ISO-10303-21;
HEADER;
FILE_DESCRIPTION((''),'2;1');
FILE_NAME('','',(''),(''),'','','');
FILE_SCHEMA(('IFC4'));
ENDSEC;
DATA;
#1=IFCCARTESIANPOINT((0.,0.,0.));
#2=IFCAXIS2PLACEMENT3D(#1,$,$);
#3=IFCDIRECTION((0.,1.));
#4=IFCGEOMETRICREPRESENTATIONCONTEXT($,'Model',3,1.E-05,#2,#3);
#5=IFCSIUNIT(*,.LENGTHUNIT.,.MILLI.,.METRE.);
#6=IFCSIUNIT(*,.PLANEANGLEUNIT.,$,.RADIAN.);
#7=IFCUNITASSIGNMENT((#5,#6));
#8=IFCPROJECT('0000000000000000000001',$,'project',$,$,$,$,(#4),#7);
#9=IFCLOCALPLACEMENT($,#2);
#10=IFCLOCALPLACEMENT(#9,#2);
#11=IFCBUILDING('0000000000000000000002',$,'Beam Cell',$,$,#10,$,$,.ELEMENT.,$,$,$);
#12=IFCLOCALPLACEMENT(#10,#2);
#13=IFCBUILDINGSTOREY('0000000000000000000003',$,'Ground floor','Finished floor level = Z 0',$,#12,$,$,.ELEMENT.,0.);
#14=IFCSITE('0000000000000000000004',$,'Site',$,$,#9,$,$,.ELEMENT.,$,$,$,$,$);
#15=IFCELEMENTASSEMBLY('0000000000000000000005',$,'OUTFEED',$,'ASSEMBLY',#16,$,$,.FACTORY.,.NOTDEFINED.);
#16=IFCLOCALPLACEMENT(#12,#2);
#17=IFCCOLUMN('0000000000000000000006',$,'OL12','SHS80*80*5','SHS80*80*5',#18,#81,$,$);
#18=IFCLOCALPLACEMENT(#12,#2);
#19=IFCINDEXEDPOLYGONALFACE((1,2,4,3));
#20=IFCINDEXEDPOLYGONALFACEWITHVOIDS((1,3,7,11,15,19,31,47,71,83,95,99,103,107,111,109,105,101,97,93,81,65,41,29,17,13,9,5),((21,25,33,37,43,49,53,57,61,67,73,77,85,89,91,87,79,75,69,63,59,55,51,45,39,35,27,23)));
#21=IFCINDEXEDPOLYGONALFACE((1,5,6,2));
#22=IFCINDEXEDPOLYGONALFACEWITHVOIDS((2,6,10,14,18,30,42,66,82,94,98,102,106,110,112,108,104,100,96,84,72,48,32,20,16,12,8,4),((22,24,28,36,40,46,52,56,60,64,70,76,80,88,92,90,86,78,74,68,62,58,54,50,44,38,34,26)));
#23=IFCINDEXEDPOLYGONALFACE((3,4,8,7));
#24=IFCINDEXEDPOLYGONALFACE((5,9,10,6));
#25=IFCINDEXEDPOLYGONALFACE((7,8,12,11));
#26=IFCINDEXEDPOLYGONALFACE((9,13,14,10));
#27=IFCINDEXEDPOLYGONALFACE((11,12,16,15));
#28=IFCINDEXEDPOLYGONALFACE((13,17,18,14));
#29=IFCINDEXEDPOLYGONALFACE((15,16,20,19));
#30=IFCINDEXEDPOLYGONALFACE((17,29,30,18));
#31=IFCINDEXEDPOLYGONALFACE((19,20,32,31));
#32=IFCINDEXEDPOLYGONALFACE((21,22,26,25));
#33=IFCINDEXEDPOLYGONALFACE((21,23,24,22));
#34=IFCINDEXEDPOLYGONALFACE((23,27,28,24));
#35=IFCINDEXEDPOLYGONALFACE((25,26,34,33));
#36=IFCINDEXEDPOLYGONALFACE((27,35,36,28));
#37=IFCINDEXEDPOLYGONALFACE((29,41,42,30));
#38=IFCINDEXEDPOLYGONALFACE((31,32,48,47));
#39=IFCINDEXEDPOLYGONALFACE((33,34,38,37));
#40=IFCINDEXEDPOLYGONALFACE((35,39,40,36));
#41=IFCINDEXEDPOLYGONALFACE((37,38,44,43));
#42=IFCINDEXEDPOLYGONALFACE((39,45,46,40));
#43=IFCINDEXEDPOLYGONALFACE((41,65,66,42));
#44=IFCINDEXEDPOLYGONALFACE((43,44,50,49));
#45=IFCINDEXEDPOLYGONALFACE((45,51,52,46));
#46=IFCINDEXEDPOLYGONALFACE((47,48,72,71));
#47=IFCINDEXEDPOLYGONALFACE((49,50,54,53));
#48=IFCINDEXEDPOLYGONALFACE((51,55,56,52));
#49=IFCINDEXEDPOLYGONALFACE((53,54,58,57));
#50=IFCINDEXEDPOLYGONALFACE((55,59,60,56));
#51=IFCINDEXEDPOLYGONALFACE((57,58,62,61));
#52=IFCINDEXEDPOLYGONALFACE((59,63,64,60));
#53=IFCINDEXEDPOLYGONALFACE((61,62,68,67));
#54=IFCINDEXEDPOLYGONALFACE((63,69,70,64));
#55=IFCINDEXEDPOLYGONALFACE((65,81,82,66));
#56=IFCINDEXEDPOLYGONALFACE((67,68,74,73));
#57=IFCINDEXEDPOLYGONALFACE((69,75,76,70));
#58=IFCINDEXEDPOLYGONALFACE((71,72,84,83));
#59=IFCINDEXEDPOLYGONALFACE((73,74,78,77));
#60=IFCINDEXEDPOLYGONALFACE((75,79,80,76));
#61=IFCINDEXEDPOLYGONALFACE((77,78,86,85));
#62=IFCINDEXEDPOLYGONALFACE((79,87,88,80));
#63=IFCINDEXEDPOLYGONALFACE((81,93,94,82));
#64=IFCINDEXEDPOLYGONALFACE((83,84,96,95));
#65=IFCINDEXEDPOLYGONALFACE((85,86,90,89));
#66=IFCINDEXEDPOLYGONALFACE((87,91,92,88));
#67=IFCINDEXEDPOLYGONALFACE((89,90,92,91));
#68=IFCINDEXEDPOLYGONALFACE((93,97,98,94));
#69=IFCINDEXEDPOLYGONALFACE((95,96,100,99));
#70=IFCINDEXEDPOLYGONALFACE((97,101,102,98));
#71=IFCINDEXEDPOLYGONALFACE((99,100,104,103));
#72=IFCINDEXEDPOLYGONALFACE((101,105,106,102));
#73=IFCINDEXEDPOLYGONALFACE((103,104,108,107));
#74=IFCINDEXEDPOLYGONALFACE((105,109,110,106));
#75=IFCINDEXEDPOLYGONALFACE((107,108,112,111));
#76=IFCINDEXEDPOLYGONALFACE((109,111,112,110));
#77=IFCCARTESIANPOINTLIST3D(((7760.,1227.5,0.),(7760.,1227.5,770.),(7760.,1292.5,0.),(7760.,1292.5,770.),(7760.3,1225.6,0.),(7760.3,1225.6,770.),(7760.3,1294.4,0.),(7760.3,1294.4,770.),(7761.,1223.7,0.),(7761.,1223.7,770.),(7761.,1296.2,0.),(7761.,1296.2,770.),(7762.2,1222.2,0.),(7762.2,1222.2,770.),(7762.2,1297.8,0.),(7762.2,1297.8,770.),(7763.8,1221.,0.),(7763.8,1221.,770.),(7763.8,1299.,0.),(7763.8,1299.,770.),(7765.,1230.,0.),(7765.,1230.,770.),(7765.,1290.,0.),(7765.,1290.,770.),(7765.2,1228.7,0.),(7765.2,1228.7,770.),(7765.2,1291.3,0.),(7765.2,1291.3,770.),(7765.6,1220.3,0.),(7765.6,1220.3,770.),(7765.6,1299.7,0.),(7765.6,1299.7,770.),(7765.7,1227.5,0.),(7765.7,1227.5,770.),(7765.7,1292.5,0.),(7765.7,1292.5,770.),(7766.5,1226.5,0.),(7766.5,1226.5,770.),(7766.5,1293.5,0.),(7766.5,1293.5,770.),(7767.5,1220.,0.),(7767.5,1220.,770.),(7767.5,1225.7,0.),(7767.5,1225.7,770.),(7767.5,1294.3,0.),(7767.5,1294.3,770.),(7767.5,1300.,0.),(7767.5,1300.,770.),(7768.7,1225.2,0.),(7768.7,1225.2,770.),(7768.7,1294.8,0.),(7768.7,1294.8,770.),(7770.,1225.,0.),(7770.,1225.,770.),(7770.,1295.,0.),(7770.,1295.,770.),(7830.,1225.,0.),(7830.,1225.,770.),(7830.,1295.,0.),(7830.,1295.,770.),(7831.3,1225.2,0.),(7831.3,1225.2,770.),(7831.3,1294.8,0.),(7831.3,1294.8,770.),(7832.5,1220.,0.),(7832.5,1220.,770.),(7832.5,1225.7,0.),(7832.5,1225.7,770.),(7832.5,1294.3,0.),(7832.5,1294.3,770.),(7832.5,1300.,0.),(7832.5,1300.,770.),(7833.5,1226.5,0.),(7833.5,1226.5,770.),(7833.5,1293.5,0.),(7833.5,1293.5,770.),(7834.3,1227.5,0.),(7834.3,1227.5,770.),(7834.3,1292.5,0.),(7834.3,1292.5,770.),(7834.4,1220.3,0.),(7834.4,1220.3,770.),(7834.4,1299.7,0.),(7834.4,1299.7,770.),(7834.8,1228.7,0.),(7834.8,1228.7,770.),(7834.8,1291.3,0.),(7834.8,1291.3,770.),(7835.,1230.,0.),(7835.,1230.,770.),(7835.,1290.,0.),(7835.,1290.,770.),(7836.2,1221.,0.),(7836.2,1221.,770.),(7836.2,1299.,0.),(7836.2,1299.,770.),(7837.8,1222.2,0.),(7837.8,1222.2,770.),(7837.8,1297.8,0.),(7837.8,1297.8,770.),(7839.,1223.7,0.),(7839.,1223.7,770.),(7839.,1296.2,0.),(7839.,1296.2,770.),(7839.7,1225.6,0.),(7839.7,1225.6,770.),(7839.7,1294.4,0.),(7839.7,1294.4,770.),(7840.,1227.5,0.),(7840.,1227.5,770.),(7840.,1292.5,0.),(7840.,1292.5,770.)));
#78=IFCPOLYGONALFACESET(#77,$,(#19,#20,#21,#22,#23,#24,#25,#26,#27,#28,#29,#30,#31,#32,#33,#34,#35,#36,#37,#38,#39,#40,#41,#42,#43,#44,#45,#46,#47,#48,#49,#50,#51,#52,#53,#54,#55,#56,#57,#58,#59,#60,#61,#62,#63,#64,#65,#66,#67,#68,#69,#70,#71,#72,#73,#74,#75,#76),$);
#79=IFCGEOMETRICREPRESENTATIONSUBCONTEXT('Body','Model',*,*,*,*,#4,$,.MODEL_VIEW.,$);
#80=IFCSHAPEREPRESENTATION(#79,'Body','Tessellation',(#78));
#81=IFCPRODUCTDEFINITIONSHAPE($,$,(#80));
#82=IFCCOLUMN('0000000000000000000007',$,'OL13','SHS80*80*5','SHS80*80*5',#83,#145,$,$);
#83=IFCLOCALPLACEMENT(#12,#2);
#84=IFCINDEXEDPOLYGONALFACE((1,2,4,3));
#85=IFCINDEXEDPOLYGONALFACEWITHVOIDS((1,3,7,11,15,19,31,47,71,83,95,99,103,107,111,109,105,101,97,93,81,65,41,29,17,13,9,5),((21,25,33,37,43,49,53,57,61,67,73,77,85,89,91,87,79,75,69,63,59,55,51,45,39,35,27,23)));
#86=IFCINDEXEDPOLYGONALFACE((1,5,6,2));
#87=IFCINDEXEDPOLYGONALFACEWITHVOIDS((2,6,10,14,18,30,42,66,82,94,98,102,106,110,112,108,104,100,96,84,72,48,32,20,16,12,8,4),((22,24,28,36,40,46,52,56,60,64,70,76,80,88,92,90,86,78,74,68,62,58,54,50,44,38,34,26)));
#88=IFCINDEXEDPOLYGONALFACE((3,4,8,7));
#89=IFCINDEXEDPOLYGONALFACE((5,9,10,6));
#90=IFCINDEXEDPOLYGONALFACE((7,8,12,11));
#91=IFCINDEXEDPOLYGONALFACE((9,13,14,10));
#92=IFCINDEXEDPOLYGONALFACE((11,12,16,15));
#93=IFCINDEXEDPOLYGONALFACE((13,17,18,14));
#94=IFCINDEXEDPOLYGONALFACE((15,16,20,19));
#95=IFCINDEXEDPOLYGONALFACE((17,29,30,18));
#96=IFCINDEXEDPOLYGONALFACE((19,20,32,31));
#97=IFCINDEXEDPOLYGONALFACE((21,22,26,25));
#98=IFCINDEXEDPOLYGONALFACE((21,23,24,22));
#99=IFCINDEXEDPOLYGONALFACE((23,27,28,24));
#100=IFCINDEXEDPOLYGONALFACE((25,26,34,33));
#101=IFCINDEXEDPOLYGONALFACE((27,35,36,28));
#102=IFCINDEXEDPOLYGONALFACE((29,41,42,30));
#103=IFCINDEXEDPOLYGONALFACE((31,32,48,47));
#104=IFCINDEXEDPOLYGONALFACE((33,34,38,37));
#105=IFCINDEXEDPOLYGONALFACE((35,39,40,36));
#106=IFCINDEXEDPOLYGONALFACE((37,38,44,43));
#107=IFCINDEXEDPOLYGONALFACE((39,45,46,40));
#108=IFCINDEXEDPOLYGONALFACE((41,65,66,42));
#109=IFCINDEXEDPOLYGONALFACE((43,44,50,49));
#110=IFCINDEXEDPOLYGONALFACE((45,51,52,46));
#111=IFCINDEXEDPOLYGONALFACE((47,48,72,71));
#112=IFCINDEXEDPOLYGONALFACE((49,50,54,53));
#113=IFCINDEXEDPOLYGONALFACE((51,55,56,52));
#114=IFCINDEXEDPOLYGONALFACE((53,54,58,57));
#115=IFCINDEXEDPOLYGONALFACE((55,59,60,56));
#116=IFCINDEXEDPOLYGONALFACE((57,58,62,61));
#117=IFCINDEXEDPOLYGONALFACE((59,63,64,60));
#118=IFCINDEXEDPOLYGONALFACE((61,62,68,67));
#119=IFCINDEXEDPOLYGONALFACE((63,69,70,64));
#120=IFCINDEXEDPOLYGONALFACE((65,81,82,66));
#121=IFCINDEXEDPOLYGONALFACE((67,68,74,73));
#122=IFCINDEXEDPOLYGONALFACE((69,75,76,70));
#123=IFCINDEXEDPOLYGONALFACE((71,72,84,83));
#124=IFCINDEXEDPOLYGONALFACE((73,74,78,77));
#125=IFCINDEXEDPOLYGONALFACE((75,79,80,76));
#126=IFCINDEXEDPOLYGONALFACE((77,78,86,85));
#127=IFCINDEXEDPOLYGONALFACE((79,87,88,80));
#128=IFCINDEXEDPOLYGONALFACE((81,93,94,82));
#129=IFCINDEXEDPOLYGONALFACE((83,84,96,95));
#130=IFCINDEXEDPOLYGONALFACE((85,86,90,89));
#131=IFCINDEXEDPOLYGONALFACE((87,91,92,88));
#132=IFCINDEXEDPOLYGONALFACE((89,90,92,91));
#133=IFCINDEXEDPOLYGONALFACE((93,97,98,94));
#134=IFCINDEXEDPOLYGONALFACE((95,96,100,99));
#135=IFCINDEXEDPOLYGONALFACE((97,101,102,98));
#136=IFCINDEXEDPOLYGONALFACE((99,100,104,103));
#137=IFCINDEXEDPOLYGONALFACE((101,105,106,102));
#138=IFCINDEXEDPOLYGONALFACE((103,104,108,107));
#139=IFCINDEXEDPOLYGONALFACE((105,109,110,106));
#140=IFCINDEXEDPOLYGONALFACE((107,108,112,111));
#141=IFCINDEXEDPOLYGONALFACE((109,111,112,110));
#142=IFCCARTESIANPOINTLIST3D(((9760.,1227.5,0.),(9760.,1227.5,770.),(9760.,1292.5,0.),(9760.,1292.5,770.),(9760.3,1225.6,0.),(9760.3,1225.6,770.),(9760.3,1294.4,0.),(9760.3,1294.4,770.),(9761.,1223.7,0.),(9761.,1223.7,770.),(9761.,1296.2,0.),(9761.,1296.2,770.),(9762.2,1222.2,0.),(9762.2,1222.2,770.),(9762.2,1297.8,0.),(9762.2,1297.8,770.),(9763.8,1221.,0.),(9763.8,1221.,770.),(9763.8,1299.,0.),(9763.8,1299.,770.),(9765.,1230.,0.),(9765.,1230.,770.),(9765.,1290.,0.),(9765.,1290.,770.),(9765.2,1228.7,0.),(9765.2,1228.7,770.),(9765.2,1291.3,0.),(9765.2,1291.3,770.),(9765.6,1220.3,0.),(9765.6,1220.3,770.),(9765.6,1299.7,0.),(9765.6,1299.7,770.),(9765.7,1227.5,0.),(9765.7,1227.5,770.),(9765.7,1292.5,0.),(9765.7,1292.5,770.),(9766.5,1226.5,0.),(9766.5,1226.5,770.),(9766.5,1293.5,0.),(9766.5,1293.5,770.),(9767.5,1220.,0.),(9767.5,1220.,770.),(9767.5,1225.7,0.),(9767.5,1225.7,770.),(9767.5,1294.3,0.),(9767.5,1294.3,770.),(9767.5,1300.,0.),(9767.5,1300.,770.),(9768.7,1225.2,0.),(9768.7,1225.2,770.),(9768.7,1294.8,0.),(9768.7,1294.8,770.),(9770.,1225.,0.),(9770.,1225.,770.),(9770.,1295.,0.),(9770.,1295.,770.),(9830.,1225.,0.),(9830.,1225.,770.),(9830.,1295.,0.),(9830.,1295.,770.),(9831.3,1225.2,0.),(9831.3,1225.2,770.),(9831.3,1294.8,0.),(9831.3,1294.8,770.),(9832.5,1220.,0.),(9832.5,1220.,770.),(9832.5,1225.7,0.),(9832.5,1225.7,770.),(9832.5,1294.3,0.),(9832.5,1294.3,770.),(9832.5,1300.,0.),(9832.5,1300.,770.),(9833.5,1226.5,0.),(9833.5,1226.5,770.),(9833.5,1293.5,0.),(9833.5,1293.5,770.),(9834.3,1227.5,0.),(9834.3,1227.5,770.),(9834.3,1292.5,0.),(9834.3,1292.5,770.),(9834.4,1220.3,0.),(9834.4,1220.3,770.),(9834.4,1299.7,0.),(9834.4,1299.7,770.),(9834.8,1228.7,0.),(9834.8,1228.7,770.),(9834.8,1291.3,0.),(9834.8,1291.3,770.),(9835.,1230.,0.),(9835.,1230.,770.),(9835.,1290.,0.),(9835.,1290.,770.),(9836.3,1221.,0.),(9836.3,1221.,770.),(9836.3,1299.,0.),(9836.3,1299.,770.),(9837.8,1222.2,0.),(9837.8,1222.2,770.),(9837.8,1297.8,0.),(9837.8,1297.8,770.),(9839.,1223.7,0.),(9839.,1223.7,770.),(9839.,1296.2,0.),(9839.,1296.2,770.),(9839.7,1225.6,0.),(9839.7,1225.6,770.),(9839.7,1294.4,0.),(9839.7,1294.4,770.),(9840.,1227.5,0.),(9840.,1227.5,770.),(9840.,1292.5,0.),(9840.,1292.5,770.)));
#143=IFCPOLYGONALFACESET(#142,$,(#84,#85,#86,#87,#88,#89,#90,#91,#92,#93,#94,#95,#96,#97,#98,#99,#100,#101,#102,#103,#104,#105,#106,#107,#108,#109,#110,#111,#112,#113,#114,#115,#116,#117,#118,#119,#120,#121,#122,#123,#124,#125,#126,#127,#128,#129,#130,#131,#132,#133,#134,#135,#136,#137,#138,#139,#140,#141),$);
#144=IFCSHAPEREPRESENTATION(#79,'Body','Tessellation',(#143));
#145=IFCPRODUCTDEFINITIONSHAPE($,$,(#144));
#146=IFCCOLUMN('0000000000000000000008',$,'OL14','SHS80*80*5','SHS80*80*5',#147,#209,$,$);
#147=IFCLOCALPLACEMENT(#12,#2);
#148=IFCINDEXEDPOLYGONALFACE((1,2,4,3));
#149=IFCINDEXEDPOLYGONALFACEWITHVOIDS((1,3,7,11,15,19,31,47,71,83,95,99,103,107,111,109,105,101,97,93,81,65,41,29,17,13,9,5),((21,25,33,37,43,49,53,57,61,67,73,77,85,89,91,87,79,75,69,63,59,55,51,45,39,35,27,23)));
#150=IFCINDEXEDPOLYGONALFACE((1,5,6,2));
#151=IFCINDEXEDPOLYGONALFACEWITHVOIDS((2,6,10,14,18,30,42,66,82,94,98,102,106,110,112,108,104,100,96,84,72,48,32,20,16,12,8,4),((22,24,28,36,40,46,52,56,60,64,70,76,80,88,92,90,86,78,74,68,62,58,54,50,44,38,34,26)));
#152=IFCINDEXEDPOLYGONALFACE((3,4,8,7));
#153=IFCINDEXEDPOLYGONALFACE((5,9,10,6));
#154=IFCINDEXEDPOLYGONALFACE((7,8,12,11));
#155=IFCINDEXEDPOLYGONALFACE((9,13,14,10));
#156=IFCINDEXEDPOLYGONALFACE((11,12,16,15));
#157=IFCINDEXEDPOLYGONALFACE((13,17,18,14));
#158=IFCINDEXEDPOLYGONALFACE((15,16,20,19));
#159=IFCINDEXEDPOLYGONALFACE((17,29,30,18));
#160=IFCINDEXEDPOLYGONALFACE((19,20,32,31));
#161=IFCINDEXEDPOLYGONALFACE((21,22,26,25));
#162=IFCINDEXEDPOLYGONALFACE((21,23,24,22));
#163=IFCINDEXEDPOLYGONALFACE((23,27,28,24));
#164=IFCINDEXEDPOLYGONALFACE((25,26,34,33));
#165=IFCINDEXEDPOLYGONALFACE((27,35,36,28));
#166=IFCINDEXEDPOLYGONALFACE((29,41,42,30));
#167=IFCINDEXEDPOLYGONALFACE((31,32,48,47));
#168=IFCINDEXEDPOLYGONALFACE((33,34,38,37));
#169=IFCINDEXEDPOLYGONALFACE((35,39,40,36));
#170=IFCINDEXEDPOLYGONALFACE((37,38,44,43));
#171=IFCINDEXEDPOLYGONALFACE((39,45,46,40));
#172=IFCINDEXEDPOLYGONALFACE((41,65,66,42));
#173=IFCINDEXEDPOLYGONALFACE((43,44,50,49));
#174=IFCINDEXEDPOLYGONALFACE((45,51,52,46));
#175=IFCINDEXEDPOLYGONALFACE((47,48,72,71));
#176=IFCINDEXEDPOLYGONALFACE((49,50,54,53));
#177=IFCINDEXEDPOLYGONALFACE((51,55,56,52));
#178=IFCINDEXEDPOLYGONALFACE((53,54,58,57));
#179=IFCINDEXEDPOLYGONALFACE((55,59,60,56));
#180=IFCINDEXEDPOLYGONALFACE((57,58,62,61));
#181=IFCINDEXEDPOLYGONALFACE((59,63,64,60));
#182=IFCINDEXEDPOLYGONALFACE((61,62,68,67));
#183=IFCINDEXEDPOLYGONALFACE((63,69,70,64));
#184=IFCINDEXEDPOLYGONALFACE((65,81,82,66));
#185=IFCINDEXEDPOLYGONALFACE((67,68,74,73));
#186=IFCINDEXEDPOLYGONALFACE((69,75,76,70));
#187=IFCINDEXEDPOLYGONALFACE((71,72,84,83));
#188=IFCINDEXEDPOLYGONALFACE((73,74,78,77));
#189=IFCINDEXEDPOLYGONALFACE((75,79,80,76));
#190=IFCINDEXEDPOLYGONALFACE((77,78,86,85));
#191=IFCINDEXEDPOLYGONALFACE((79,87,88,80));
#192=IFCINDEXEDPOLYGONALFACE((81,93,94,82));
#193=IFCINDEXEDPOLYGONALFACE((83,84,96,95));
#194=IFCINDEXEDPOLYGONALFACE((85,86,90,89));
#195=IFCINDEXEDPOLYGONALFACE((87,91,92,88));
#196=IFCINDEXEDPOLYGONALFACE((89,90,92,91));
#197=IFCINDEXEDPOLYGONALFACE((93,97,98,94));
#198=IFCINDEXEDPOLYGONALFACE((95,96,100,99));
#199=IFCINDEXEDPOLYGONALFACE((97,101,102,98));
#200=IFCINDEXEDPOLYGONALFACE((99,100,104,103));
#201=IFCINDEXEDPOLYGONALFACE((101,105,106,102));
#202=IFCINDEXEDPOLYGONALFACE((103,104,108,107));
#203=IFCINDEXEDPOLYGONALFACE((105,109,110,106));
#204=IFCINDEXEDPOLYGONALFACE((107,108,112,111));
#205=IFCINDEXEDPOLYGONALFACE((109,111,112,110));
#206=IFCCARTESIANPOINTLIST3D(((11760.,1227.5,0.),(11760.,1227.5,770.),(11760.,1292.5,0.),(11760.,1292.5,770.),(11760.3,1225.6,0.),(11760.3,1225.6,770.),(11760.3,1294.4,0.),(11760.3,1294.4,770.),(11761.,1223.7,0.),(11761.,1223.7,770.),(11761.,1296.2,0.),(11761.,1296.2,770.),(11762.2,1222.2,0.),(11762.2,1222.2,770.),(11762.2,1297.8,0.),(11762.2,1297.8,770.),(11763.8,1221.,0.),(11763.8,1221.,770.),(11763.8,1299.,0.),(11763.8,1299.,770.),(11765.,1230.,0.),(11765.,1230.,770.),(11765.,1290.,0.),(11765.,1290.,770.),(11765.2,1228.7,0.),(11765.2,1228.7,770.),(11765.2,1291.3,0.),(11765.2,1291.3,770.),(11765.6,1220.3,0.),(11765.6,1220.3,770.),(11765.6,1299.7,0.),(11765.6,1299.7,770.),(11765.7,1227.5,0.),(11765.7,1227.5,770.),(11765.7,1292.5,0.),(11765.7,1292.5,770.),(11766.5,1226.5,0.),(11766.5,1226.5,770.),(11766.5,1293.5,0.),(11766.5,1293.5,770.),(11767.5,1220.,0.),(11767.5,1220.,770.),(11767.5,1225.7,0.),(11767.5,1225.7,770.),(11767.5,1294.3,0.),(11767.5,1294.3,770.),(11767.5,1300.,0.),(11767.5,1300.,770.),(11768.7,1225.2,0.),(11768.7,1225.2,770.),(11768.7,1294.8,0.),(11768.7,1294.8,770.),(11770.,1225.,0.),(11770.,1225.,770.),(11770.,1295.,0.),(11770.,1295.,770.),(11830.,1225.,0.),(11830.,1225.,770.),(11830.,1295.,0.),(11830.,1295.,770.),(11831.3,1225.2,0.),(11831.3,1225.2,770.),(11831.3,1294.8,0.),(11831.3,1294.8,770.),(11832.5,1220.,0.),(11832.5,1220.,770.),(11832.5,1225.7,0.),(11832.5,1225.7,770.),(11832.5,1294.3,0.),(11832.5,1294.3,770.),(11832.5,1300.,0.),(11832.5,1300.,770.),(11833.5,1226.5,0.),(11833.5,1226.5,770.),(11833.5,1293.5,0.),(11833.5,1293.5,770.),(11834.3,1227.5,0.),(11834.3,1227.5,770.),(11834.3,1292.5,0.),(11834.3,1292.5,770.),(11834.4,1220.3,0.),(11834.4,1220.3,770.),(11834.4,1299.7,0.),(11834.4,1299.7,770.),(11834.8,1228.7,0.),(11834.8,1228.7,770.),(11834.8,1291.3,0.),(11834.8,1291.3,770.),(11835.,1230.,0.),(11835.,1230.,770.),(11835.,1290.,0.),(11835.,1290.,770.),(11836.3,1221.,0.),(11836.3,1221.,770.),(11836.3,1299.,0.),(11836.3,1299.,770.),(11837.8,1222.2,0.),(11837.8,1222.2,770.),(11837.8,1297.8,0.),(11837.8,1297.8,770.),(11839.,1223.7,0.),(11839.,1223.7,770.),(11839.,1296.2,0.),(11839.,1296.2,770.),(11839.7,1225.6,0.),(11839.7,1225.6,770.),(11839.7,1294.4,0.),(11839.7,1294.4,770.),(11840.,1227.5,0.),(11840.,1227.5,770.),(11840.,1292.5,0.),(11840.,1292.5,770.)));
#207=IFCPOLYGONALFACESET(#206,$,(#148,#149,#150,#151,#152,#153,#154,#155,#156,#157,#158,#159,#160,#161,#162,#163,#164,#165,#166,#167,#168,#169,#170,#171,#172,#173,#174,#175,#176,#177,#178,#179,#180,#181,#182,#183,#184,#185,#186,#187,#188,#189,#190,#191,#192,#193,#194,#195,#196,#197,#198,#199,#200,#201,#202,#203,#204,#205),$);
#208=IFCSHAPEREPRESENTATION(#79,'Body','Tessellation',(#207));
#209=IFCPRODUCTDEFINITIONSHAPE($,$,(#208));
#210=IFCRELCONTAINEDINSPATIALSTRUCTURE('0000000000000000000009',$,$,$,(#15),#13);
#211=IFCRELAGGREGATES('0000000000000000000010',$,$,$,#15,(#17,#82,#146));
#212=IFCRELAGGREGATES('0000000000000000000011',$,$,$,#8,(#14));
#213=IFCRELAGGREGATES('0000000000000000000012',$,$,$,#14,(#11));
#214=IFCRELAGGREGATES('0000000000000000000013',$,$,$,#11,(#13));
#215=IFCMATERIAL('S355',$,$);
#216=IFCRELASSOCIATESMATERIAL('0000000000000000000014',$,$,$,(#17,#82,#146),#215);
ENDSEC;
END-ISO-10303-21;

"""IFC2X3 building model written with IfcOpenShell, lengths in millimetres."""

from ifc_helpers import new_model, si_unit, direction, frame, origin, origin_2d, place, context, subcontext, project, spatial, hollow_rectangle, extrude, material, element, aggregate, save


model = new_model("IFC2X3")

# Units and contexts
model_context = context("Model", 3, precision=1e-05, world=origin(), true_north=direction((0.0, 1.0)))
body_context = subcontext(model_context, "Body", "Model", "MODEL_VIEW")
ifc_project = project(units=[si_unit("LENGTHUNIT", "METRE", prefix="MILLI"), si_unit("PLANEANGLEUNIT", "RADIAN")], contexts=[model_context])

# Site, building, storey
site_placement = place(None, origin())
site = spatial("IfcSite", under=ifc_project, at=site_placement, Name="Site", CompositionType="ELEMENT")
building_placement = place(site_placement, origin())
building = spatial("IfcBuilding", under=site, at=building_placement, Name="Beam Cell", CompositionType="ELEMENT")
storey_placement = place(building_placement, origin())
storey = spatial("IfcBuildingStorey", under=building, at=storey_placement, Name="Ground floor", Description="Finished floor level = Z 0", CompositionType="ELEMENT", Elevation=0.0)

# Element assembly, columns
ifc_material = material(Name="S355")
assembly_1_placement = place(storey_placement, origin())
assembly_1 = element("IfcElementAssembly", 1, at=assembly_1_placement, inside=storey, Name="OUTFEED", ObjectType="ASSEMBLY", AssemblyPlace="FACTORY", PredefinedType="NOTDEFINED")
column_1_placement = place(storey_placement, frame((7800.0, 1260.0, 0.0), z_axis=(0.0, 0.0, 1.0), x_axis=(1.0, 0.0, 0.0)))
column_1 = element("IfcColumn", 2, at=column_1_placement, material=ifc_material, Name="OL12", Description="SHS80*80*5", ObjectType="SHS80*80*5", context=body_context, shape_type="SweptSolid", body=[
    extrude(hollow_rectangle(XDim=80.0, YDim=80.0, WallThickness=5.0, InnerFilletRadius=5.0, OuterFilletRadius=7.5, at=origin_2d()), origin(), (0.0, 0.0, 1.0), 770.0),
])
column_2_placement = place(storey_placement, frame((9800.0, 1260.0, 0.0), z_axis=(0.0, 0.0, 1.0), x_axis=(1.0, 0.0, 0.0)))
column_2 = element("IfcColumn", 3, at=column_2_placement, material=ifc_material, Name="OL13", Description="SHS80*80*5", ObjectType="SHS80*80*5", context=body_context, shape_type="SweptSolid", body=[
    extrude(hollow_rectangle(XDim=80.0, YDim=80.0, WallThickness=5.0, InnerFilletRadius=5.0, OuterFilletRadius=7.5, at=origin_2d()), origin(), (0.0, 0.0, 1.0), 770.0),
])
column_3_placement = place(storey_placement, frame((11800.0, 1260.0, 0.0), z_axis=(0.0, 0.0, 1.0), x_axis=(1.0, 0.0, 0.0)))
column_3 = element("IfcColumn", 4, at=column_3_placement, material=ifc_material, Name="OL14", Description="SHS80*80*5", ObjectType="SHS80*80*5", context=body_context, shape_type="SweptSolid", body=[
    extrude(hollow_rectangle(XDim=80.0, YDim=80.0, WallThickness=5.0, InnerFilletRadius=5.0, OuterFilletRadius=7.5, at=origin_2d()), origin(), (0.0, 0.0, 1.0), 770.0),
])
aggregate(assembly_1, [column_1, column_2, column_3])

save(model, "model.ifc")
